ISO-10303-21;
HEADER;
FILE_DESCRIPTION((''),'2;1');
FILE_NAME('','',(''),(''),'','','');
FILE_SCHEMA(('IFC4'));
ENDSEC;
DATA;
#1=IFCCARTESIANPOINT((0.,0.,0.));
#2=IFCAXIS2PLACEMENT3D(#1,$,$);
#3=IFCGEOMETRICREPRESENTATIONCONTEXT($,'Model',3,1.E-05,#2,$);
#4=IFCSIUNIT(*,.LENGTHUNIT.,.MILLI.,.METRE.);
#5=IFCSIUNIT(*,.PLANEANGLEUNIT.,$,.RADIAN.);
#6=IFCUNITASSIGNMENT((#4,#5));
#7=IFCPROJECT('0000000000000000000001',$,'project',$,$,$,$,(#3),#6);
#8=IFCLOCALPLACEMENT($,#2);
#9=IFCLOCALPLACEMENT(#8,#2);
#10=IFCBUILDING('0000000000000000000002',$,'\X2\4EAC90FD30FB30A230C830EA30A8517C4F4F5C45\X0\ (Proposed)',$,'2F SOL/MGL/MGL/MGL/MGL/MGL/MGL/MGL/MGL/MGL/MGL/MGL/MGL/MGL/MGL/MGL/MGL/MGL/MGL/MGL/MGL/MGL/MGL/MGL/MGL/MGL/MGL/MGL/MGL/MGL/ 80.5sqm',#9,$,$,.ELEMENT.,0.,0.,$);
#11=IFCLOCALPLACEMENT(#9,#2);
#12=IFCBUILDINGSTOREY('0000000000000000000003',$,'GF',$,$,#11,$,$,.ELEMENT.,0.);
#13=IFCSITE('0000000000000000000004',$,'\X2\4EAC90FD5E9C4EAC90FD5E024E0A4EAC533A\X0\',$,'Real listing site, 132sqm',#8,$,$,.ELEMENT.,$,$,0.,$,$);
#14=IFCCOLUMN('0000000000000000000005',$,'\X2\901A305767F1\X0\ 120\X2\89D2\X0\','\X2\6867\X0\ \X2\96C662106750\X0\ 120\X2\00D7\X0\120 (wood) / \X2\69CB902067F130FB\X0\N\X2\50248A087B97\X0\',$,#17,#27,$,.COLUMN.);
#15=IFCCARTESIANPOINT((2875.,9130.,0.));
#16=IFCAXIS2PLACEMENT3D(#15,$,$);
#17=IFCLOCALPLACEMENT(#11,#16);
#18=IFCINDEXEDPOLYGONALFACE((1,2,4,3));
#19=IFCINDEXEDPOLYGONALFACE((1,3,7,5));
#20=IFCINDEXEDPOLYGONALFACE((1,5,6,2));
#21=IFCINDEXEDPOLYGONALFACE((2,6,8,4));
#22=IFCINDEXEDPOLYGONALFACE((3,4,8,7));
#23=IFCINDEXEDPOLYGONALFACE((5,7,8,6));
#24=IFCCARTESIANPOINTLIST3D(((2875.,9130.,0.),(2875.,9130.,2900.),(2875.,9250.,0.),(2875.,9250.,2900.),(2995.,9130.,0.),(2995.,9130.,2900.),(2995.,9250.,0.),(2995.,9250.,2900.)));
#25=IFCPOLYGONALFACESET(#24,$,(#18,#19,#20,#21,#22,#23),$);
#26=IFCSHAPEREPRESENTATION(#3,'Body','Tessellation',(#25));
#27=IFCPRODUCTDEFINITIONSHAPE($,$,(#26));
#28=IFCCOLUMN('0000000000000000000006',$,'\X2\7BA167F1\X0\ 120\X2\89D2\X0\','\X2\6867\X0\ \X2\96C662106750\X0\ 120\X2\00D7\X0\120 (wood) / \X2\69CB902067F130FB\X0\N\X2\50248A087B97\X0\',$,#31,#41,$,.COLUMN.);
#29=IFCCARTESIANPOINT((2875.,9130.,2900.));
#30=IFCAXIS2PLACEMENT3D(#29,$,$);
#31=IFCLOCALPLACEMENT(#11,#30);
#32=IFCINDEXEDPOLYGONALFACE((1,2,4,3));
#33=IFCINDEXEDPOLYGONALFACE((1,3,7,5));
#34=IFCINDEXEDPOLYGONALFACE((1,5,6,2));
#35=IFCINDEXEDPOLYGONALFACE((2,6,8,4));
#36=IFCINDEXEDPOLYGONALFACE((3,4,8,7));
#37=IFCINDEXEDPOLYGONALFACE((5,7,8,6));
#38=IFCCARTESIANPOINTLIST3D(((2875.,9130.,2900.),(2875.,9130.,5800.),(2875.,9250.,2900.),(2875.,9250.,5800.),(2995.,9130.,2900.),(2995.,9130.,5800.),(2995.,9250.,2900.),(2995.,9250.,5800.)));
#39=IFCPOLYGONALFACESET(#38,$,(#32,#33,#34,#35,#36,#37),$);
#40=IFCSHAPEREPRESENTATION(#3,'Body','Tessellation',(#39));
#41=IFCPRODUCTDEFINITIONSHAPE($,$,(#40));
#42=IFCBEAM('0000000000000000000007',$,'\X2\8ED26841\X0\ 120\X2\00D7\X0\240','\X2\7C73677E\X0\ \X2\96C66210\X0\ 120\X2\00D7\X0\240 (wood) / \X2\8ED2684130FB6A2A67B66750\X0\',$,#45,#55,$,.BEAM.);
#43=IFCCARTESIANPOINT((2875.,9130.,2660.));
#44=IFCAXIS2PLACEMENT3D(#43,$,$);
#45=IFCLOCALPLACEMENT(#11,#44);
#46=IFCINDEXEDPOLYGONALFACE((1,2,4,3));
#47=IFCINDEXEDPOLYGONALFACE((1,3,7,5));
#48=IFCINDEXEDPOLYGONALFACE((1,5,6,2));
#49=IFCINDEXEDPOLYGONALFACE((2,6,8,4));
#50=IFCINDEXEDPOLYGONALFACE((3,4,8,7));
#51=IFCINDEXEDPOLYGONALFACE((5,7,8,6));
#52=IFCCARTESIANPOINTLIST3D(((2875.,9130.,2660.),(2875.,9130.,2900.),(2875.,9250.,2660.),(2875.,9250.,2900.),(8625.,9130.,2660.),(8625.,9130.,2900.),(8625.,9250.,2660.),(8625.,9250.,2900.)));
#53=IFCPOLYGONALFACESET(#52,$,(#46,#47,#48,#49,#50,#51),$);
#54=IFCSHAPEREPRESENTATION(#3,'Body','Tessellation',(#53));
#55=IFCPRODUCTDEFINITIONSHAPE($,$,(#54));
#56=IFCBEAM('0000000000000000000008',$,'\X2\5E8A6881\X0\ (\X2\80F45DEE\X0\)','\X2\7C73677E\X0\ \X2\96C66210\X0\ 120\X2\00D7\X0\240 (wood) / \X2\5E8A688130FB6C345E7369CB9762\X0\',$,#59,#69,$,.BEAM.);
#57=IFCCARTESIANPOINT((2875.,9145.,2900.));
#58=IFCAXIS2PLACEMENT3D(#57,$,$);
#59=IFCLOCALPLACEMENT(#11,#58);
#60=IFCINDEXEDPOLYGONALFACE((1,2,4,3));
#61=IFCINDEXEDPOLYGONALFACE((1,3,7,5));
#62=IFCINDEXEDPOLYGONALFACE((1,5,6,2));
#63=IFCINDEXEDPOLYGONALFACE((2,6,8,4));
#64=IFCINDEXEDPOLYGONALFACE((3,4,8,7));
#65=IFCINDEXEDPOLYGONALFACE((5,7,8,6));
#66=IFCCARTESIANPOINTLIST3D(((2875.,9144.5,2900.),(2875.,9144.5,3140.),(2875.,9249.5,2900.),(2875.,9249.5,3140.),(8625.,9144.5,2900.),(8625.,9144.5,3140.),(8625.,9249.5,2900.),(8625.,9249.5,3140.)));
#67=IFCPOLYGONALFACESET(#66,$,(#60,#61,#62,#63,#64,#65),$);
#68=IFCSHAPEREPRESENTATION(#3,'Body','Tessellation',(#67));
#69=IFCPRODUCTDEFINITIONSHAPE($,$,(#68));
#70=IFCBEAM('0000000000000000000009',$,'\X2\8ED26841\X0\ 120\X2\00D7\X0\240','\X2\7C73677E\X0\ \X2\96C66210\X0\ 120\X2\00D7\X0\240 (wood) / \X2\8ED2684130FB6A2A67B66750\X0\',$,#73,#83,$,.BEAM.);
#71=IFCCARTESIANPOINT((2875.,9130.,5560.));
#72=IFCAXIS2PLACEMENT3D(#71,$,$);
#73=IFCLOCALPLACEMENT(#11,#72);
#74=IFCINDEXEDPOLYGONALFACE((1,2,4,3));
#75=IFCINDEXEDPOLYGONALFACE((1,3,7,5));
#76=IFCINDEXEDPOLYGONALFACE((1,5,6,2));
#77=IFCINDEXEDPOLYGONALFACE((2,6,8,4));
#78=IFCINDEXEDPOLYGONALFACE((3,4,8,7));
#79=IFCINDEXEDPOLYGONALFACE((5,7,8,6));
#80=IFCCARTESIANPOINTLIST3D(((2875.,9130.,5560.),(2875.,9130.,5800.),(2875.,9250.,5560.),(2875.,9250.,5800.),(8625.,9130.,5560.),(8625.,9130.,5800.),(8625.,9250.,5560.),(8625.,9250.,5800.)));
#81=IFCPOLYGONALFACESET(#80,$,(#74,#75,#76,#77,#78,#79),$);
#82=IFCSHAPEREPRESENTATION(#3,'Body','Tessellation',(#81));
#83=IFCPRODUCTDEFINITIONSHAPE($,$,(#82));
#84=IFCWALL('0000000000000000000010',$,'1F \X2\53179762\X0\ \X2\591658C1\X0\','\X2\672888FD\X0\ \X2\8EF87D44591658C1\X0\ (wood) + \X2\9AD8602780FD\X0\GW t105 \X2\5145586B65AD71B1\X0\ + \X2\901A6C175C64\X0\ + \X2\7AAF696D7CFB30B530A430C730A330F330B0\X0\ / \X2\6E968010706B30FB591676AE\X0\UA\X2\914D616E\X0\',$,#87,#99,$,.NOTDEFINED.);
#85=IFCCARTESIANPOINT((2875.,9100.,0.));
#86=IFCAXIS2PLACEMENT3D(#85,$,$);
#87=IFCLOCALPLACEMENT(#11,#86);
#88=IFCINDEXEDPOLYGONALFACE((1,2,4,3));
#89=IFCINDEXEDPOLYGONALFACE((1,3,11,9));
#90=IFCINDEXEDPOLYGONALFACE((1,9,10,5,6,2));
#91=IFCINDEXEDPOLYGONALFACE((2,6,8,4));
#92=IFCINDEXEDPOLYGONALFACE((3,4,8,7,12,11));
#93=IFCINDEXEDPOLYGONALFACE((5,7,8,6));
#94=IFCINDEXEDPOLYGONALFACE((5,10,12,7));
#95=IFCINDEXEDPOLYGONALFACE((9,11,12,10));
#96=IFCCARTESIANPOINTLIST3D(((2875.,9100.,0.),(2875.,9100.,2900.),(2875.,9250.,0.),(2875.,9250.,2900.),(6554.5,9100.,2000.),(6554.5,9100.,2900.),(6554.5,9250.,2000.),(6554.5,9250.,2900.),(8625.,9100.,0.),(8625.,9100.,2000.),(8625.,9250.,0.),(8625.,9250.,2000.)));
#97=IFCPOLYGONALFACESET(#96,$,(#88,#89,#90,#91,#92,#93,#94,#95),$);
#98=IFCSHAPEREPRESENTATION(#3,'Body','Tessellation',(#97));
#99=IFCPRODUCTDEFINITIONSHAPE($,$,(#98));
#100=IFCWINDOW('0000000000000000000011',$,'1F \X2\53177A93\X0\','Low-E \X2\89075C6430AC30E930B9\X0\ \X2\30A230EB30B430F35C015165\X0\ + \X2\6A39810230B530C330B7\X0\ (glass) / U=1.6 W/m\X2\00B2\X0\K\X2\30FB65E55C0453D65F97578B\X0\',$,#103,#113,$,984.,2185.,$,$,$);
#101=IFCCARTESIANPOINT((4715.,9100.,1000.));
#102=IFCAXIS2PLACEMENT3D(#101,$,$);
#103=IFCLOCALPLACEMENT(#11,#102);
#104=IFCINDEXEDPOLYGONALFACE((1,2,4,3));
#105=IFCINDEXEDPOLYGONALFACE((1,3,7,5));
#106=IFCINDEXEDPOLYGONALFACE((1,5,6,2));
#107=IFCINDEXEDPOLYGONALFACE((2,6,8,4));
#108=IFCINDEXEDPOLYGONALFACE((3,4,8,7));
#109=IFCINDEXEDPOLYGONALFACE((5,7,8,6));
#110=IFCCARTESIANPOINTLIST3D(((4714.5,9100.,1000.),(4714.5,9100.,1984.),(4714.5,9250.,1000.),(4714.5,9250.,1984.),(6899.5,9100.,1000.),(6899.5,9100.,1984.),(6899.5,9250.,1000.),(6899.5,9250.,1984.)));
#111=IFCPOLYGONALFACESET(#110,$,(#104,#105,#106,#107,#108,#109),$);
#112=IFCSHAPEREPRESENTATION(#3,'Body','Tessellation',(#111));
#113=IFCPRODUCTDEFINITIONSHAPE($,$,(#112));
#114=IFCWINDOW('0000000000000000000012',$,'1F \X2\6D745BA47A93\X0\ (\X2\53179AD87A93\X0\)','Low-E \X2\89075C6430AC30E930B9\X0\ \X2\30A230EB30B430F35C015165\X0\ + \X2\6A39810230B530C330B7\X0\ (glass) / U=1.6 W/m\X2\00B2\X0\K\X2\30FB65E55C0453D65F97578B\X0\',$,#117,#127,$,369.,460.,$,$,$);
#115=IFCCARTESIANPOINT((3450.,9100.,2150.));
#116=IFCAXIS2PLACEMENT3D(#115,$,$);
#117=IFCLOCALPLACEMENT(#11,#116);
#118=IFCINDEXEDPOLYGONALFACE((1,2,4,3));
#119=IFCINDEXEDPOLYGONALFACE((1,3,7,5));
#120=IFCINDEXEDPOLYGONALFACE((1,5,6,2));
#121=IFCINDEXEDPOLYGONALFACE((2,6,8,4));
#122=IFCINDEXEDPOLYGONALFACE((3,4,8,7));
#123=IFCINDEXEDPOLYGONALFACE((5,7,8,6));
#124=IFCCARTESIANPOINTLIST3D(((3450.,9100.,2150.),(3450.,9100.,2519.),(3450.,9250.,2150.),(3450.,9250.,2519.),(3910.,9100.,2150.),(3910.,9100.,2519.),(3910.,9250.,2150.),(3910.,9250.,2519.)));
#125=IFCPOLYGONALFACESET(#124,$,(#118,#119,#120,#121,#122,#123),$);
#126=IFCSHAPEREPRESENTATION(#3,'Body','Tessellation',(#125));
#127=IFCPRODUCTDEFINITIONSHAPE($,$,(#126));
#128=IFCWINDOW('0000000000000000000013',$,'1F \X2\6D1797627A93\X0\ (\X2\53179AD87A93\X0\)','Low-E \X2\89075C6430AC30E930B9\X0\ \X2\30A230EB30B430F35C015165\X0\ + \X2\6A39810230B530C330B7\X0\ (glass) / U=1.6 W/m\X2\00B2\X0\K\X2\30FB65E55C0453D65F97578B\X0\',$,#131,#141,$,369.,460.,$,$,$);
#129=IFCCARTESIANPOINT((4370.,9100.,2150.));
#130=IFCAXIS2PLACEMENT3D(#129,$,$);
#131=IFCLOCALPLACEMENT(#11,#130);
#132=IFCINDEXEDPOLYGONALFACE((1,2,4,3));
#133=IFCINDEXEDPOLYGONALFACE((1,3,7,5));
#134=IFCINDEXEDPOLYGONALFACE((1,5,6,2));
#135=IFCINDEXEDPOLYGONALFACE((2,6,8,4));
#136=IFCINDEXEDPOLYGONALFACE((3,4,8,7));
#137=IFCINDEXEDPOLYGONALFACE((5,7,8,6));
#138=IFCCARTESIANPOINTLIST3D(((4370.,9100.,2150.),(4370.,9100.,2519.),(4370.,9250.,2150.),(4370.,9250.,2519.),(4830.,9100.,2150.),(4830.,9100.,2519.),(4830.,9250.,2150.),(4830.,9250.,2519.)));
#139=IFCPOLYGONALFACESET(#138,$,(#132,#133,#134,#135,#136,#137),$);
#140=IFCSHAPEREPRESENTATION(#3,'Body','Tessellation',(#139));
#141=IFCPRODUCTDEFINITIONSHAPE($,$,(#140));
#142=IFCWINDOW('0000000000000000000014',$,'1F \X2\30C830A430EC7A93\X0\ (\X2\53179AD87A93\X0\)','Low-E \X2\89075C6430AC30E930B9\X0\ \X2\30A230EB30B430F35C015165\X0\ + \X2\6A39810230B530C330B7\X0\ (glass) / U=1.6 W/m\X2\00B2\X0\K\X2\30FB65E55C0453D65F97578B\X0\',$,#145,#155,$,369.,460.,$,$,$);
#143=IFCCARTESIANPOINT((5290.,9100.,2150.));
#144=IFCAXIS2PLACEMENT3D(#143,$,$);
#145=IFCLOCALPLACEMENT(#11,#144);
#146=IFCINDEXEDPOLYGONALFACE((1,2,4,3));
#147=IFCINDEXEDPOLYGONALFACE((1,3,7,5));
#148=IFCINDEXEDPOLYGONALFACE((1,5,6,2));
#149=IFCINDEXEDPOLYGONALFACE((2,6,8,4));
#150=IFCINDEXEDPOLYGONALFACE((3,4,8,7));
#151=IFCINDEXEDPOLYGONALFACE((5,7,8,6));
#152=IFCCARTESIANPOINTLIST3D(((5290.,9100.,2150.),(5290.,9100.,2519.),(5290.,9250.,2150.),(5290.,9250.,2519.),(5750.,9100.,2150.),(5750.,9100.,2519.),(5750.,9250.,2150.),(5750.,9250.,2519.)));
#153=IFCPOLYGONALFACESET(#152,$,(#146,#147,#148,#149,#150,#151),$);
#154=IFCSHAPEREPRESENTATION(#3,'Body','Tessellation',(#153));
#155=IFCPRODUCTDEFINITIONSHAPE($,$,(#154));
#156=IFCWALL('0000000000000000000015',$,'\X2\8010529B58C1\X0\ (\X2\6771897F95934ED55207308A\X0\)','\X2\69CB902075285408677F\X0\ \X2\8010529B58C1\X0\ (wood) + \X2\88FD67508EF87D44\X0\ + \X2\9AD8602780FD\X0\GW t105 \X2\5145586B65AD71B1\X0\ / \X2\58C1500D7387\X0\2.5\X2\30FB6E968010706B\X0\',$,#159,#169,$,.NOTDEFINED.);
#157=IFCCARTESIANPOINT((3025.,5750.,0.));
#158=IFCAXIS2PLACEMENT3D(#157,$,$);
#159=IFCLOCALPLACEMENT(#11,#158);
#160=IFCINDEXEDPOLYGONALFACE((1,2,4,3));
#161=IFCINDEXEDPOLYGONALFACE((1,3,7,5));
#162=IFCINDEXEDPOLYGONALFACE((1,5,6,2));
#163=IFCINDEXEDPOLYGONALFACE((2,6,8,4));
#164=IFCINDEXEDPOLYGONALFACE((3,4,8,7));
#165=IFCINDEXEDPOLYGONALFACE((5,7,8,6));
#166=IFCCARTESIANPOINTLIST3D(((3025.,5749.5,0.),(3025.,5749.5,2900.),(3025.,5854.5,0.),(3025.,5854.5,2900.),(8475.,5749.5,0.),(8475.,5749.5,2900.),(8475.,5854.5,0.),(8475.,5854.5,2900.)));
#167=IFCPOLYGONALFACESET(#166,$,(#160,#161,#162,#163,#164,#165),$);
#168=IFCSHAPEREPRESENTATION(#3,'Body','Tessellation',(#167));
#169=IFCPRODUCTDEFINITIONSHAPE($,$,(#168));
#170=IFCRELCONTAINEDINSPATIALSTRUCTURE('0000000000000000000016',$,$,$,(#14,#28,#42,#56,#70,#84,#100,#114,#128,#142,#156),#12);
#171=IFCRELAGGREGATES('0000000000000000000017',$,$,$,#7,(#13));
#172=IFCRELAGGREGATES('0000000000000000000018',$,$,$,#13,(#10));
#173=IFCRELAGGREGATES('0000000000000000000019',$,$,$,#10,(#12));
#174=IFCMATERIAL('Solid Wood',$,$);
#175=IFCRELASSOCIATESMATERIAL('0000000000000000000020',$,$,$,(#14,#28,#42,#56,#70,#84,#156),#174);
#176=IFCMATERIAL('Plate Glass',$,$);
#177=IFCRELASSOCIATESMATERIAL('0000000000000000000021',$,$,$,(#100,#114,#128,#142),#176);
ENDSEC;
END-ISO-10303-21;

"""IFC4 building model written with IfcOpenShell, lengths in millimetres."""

from ifc_helpers import new_model, si_unit, frame, frame_2d, origin, place, context, project, spatial, rectangle, extrude, material, element, fill, save


model = new_model("IFC4")

# Units and contexts
model_context = context("Model", 3, precision=1e-05, world=origin())
ifc_project = project(units=[si_unit("LENGTHUNIT", "METRE", prefix="MILLI"), si_unit("PLANEANGLEUNIT", "RADIAN")], contexts=[model_context])

# Site, building, storey
site_placement = place(None, origin())
site = spatial("IfcSite", under=ifc_project, at=site_placement, Name="京都府京都市上京区", ObjectType="Real listing site, 132sqm", CompositionType="ELEMENT", RefElevation=0.0)
building_placement = place(site_placement, origin())
building = spatial("IfcBuilding", under=site, at=building_placement, Name="京都・アトリエ兼住居 (Proposed)", ObjectType="2F SOL/MGL/MGL/MGL/MGL/MGL/MGL/MGL/MGL/MGL/MGL/MGL/MGL/MGL/MGL/MGL/MGL/MGL/MGL/MGL/MGL/MGL/MGL/MGL/MGL/MGL/MGL/MGL/MGL/MGL/ 80.5sqm", CompositionType="ELEMENT", ElevationOfRefHeight=0.0, ElevationOfTerrain=0.0)
storey_placement = place(building_placement, origin())
storey = spatial("IfcBuildingStorey", under=building, at=storey_placement, Name="GF", CompositionType="ELEMENT", Elevation=0.0)

# Columns
ifc_material_1 = material(Name="Solid Wood")
column_1_placement = place(storey_placement, frame((2875.0, 9130.0, 0.0)))
element("IfcColumn", 1, at=column_1_placement, inside=storey, material=ifc_material_1, Name="通し柱 120角", Description="桧 集成材 120×120 (wood) / 構造柱・N値計算", PredefinedType="COLUMN", context=model_context, shape_type="SweptSolid", body=[
    extrude(rectangle(XDim=120.0, YDim=120.0, at=frame_2d((60.0, 60.0))), frame((2875.0, 9130.0, 0.0)), (0.0, 0.0, 1.0), 2900.0),
])
column_2_placement = place(storey_placement, frame((2875.0, 9130.0, 2900.0)))
element("IfcColumn", 2, at=column_2_placement, inside=storey, material=ifc_material_1, Name="管柱 120角", Description="桧 集成材 120×120 (wood) / 構造柱・N値計算", PredefinedType="COLUMN", context=model_context, shape_type="SweptSolid", body=[
    extrude(rectangle(XDim=120.0, YDim=120.0, at=frame_2d((60.0, 60.0))), frame((2875.0, 9130.0, 2900.0)), (0.0, 0.0, 1.0), 2900.0),
])

# Beams
beam_1_placement = place(storey_placement, frame((2875.0, 9130.0, 2660.0)))
element("IfcBeam", 3, at=beam_1_placement, inside=storey, material=ifc_material_1, Name="軒桁 120×240", Description="米松 集成 120×240 (wood) / 軒桁・横架材", PredefinedType="BEAM", context=model_context, shape_type="SweptSolid", body=[
    extrude(rectangle(XDim=5750.0, YDim=120.0, at=frame_2d((2875.0, 60.0))), frame((2875.0, 9130.0, 2660.0)), (0.0, 0.0, 1.0), 240.0),
])
beam_2_placement = place(storey_placement, frame((2875.0, 9145.0, 2900.0)))
element("IfcBeam", 4, at=beam_2_placement, inside=storey, material=ifc_material_1, Name="床梁 (胴差)", Description="米松 集成 120×240 (wood) / 床梁・水平構面", PredefinedType="BEAM", context=model_context, shape_type="SweptSolid", body=[
    extrude(rectangle(XDim=5750.0, YDim=105.0, at=frame_2d((2875.0, 52.0))), frame((2875.0, 9145.0, 2900.0)), (0.0, 0.0, 1.0), 240.0),
])
beam_3_placement = place(storey_placement, frame((2875.0, 9130.0, 5560.0)))
element("IfcBeam", 5, at=beam_3_placement, inside=storey, material=ifc_material_1, Name="軒桁 120×240", Description="米松 集成 120×240 (wood) / 軒桁・横架材", PredefinedType="BEAM", context=model_context, shape_type="SweptSolid", body=[
    extrude(rectangle(XDim=5750.0, YDim=120.0, at=frame_2d((2875.0, 60.0))), frame((2875.0, 9130.0, 5560.0)), (0.0, 0.0, 1.0), 240.0),
])

# Wall, openings, windows
wall_1_placement = place(storey_placement, frame((2875.0, 9100.0, 0.0)))
wall_1 = element("IfcWall", 6, at=wall_1_placement, inside=storey, material=ifc_material_1, Name="1F 北面 外壁", Description="木製 軸組外壁 (wood) + 高性能GW t105 充填断熱 + 通気層 + 窯業系サイディング / 準耐火・外皮UA配慮", PredefinedType="NOTDEFINED", context=model_context, shape_type="SweptSolid", body=[
    extrude(rectangle(XDim=5750.0, YDim=150.0, at=frame_2d((2875.0, 75.0))), frame((2875.0, 9100.0, 0.0)), (0.0, 0.0, 1.0), 2900.0),
])
opening_1_placement = place(storey_placement, frame((4715.0, 9100.0, 1000.0)))
opening_1 = element("IfcOpeningElement", 7, at=opening_1_placement, cuts=wall_1, PredefinedType="NOTDEFINED", context=model_context, shape_type="SweptSolid", body=[
    extrude(rectangle(XDim=2185.0, YDim=150.0, at=frame_2d((1092.0, 75.0))), frame((4715.0, 9100.0, 1000.0)), (0.0, 0.0, 1.0), 984.0),
])
opening_2_placement = place(storey_placement, frame((3450.0, 9100.0, 2150.0)))
opening_2 = element("IfcOpeningElement", 8, at=opening_2_placement, cuts=wall_1, PredefinedType="NOTDEFINED", context=model_context, shape_type="SweptSolid", body=[
    extrude(rectangle(XDim=460.0, YDim=150.0, at=frame_2d((230.0, 75.0))), frame((3450.0, 9100.0, 2150.0)), (0.0, 0.0, 1.0), 369.0),
])
opening_3_placement = place(storey_placement, frame((4370.0, 9100.0, 2150.0)))
opening_3 = element("IfcOpeningElement", 9, at=opening_3_placement, cuts=wall_1, PredefinedType="NOTDEFINED", context=model_context, shape_type="SweptSolid", body=[
    extrude(rectangle(XDim=460.0, YDim=150.0, at=frame_2d((230.0, 75.0))), frame((4370.0, 9100.0, 2150.0)), (0.0, 0.0, 1.0), 369.0),
])
opening_4_placement = place(storey_placement, frame((5290.0, 9100.0, 2150.0)))
opening_4 = element("IfcOpeningElement", 10, at=opening_4_placement, cuts=wall_1, PredefinedType="NOTDEFINED", context=model_context, shape_type="SweptSolid", body=[
    extrude(rectangle(XDim=460.0, YDim=150.0, at=frame_2d((230.0, 75.0))), frame((5290.0, 9100.0, 2150.0)), (0.0, 0.0, 1.0), 369.0),
])
ifc_material_2 = material(Name="Plate Glass")
window_1_placement = place(storey_placement, frame((4715.0, 9100.0, 1000.0)))
window_1 = element("IfcWindow", 11, at=window_1_placement, inside=storey, material=ifc_material_2, Name="1F 北窓", Description="Low-E 複層ガラス アルゴン封入 + 樹脂サッシ (glass) / U=1.6 W/m²K・日射取得型", OverallHeight=984.0, OverallWidth=2185.0, context=model_context, shape_type="SweptSolid", body=[
    extrude(rectangle(XDim=2185.0, YDim=150.0, at=frame_2d((1092.0, 75.0))), frame((4715.0, 9100.0, 1000.0)), (0.0, 0.0, 1.0), 984.0),
])
fill(opening_1, window_1)
window_2_placement = place(storey_placement, frame((3450.0, 9100.0, 2150.0)))
window_2 = element("IfcWindow", 12, at=window_2_placement, inside=storey, material=ifc_material_2, Name="1F 浴室窓 (北高窓)", Description="Low-E 複層ガラス アルゴン封入 + 樹脂サッシ (glass) / U=1.6 W/m²K・日射取得型", OverallHeight=369.0, OverallWidth=460.0, context=model_context, shape_type="SweptSolid", body=[
    extrude(rectangle(XDim=460.0, YDim=150.0, at=frame_2d((230.0, 75.0))), frame((3450.0, 9100.0, 2150.0)), (0.0, 0.0, 1.0), 369.0),
])
fill(opening_2, window_2)
window_3_placement = place(storey_placement, frame((4370.0, 9100.0, 2150.0)))
window_3 = element("IfcWindow", 13, at=window_3_placement, inside=storey, material=ifc_material_2, Name="1F 洗面窓 (北高窓)", Description="Low-E 複層ガラス アルゴン封入 + 樹脂サッシ (glass) / U=1.6 W/m²K・日射取得型", OverallHeight=369.0, OverallWidth=460.0, context=model_context, shape_type="SweptSolid", body=[
    extrude(rectangle(XDim=460.0, YDim=150.0, at=frame_2d((230.0, 75.0))), frame((4370.0, 9100.0, 2150.0)), (0.0, 0.0, 1.0), 369.0),
])
fill(opening_3, window_3)
window_4_placement = place(storey_placement, frame((5290.0, 9100.0, 2150.0)))
window_4 = element("IfcWindow", 14, at=window_4_placement, inside=storey, material=ifc_material_2, Name="1F トイレ窓 (北高窓)", Description="Low-E 複層ガラス アルゴン封入 + 樹脂サッシ (glass) / U=1.6 W/m²K・日射取得型", OverallHeight=369.0, OverallWidth=460.0, context=model_context, shape_type="SweptSolid", body=[
    extrude(rectangle(XDim=460.0, YDim=150.0, at=frame_2d((230.0, 75.0))), frame((5290.0, 9100.0, 2150.0)), (0.0, 0.0, 1.0), 369.0),
])
fill(opening_4, window_4)

# Wall
wall_2_placement = place(storey_placement, frame((3025.0, 5750.0, 0.0)))
element("IfcWall", 15, at=wall_2_placement, inside=storey, material=ifc_material_1, Name="耐力壁 (東西間仕切り)", Description="構造用合板 耐力壁 (wood) + 製材軸組 + 高性能GW t105 充填断熱 / 壁倍率2.5・準耐火", PredefinedType="NOTDEFINED", context=model_context, shape_type="SweptSolid", body=[
    extrude(rectangle(XDim=5450.0, YDim=105.0, at=frame_2d((2725.0, 52.0))), frame((3025.0, 5750.0, 0.0)), (0.0, 0.0, 1.0), 2900.0),
])

save(model, "model.ifc")
